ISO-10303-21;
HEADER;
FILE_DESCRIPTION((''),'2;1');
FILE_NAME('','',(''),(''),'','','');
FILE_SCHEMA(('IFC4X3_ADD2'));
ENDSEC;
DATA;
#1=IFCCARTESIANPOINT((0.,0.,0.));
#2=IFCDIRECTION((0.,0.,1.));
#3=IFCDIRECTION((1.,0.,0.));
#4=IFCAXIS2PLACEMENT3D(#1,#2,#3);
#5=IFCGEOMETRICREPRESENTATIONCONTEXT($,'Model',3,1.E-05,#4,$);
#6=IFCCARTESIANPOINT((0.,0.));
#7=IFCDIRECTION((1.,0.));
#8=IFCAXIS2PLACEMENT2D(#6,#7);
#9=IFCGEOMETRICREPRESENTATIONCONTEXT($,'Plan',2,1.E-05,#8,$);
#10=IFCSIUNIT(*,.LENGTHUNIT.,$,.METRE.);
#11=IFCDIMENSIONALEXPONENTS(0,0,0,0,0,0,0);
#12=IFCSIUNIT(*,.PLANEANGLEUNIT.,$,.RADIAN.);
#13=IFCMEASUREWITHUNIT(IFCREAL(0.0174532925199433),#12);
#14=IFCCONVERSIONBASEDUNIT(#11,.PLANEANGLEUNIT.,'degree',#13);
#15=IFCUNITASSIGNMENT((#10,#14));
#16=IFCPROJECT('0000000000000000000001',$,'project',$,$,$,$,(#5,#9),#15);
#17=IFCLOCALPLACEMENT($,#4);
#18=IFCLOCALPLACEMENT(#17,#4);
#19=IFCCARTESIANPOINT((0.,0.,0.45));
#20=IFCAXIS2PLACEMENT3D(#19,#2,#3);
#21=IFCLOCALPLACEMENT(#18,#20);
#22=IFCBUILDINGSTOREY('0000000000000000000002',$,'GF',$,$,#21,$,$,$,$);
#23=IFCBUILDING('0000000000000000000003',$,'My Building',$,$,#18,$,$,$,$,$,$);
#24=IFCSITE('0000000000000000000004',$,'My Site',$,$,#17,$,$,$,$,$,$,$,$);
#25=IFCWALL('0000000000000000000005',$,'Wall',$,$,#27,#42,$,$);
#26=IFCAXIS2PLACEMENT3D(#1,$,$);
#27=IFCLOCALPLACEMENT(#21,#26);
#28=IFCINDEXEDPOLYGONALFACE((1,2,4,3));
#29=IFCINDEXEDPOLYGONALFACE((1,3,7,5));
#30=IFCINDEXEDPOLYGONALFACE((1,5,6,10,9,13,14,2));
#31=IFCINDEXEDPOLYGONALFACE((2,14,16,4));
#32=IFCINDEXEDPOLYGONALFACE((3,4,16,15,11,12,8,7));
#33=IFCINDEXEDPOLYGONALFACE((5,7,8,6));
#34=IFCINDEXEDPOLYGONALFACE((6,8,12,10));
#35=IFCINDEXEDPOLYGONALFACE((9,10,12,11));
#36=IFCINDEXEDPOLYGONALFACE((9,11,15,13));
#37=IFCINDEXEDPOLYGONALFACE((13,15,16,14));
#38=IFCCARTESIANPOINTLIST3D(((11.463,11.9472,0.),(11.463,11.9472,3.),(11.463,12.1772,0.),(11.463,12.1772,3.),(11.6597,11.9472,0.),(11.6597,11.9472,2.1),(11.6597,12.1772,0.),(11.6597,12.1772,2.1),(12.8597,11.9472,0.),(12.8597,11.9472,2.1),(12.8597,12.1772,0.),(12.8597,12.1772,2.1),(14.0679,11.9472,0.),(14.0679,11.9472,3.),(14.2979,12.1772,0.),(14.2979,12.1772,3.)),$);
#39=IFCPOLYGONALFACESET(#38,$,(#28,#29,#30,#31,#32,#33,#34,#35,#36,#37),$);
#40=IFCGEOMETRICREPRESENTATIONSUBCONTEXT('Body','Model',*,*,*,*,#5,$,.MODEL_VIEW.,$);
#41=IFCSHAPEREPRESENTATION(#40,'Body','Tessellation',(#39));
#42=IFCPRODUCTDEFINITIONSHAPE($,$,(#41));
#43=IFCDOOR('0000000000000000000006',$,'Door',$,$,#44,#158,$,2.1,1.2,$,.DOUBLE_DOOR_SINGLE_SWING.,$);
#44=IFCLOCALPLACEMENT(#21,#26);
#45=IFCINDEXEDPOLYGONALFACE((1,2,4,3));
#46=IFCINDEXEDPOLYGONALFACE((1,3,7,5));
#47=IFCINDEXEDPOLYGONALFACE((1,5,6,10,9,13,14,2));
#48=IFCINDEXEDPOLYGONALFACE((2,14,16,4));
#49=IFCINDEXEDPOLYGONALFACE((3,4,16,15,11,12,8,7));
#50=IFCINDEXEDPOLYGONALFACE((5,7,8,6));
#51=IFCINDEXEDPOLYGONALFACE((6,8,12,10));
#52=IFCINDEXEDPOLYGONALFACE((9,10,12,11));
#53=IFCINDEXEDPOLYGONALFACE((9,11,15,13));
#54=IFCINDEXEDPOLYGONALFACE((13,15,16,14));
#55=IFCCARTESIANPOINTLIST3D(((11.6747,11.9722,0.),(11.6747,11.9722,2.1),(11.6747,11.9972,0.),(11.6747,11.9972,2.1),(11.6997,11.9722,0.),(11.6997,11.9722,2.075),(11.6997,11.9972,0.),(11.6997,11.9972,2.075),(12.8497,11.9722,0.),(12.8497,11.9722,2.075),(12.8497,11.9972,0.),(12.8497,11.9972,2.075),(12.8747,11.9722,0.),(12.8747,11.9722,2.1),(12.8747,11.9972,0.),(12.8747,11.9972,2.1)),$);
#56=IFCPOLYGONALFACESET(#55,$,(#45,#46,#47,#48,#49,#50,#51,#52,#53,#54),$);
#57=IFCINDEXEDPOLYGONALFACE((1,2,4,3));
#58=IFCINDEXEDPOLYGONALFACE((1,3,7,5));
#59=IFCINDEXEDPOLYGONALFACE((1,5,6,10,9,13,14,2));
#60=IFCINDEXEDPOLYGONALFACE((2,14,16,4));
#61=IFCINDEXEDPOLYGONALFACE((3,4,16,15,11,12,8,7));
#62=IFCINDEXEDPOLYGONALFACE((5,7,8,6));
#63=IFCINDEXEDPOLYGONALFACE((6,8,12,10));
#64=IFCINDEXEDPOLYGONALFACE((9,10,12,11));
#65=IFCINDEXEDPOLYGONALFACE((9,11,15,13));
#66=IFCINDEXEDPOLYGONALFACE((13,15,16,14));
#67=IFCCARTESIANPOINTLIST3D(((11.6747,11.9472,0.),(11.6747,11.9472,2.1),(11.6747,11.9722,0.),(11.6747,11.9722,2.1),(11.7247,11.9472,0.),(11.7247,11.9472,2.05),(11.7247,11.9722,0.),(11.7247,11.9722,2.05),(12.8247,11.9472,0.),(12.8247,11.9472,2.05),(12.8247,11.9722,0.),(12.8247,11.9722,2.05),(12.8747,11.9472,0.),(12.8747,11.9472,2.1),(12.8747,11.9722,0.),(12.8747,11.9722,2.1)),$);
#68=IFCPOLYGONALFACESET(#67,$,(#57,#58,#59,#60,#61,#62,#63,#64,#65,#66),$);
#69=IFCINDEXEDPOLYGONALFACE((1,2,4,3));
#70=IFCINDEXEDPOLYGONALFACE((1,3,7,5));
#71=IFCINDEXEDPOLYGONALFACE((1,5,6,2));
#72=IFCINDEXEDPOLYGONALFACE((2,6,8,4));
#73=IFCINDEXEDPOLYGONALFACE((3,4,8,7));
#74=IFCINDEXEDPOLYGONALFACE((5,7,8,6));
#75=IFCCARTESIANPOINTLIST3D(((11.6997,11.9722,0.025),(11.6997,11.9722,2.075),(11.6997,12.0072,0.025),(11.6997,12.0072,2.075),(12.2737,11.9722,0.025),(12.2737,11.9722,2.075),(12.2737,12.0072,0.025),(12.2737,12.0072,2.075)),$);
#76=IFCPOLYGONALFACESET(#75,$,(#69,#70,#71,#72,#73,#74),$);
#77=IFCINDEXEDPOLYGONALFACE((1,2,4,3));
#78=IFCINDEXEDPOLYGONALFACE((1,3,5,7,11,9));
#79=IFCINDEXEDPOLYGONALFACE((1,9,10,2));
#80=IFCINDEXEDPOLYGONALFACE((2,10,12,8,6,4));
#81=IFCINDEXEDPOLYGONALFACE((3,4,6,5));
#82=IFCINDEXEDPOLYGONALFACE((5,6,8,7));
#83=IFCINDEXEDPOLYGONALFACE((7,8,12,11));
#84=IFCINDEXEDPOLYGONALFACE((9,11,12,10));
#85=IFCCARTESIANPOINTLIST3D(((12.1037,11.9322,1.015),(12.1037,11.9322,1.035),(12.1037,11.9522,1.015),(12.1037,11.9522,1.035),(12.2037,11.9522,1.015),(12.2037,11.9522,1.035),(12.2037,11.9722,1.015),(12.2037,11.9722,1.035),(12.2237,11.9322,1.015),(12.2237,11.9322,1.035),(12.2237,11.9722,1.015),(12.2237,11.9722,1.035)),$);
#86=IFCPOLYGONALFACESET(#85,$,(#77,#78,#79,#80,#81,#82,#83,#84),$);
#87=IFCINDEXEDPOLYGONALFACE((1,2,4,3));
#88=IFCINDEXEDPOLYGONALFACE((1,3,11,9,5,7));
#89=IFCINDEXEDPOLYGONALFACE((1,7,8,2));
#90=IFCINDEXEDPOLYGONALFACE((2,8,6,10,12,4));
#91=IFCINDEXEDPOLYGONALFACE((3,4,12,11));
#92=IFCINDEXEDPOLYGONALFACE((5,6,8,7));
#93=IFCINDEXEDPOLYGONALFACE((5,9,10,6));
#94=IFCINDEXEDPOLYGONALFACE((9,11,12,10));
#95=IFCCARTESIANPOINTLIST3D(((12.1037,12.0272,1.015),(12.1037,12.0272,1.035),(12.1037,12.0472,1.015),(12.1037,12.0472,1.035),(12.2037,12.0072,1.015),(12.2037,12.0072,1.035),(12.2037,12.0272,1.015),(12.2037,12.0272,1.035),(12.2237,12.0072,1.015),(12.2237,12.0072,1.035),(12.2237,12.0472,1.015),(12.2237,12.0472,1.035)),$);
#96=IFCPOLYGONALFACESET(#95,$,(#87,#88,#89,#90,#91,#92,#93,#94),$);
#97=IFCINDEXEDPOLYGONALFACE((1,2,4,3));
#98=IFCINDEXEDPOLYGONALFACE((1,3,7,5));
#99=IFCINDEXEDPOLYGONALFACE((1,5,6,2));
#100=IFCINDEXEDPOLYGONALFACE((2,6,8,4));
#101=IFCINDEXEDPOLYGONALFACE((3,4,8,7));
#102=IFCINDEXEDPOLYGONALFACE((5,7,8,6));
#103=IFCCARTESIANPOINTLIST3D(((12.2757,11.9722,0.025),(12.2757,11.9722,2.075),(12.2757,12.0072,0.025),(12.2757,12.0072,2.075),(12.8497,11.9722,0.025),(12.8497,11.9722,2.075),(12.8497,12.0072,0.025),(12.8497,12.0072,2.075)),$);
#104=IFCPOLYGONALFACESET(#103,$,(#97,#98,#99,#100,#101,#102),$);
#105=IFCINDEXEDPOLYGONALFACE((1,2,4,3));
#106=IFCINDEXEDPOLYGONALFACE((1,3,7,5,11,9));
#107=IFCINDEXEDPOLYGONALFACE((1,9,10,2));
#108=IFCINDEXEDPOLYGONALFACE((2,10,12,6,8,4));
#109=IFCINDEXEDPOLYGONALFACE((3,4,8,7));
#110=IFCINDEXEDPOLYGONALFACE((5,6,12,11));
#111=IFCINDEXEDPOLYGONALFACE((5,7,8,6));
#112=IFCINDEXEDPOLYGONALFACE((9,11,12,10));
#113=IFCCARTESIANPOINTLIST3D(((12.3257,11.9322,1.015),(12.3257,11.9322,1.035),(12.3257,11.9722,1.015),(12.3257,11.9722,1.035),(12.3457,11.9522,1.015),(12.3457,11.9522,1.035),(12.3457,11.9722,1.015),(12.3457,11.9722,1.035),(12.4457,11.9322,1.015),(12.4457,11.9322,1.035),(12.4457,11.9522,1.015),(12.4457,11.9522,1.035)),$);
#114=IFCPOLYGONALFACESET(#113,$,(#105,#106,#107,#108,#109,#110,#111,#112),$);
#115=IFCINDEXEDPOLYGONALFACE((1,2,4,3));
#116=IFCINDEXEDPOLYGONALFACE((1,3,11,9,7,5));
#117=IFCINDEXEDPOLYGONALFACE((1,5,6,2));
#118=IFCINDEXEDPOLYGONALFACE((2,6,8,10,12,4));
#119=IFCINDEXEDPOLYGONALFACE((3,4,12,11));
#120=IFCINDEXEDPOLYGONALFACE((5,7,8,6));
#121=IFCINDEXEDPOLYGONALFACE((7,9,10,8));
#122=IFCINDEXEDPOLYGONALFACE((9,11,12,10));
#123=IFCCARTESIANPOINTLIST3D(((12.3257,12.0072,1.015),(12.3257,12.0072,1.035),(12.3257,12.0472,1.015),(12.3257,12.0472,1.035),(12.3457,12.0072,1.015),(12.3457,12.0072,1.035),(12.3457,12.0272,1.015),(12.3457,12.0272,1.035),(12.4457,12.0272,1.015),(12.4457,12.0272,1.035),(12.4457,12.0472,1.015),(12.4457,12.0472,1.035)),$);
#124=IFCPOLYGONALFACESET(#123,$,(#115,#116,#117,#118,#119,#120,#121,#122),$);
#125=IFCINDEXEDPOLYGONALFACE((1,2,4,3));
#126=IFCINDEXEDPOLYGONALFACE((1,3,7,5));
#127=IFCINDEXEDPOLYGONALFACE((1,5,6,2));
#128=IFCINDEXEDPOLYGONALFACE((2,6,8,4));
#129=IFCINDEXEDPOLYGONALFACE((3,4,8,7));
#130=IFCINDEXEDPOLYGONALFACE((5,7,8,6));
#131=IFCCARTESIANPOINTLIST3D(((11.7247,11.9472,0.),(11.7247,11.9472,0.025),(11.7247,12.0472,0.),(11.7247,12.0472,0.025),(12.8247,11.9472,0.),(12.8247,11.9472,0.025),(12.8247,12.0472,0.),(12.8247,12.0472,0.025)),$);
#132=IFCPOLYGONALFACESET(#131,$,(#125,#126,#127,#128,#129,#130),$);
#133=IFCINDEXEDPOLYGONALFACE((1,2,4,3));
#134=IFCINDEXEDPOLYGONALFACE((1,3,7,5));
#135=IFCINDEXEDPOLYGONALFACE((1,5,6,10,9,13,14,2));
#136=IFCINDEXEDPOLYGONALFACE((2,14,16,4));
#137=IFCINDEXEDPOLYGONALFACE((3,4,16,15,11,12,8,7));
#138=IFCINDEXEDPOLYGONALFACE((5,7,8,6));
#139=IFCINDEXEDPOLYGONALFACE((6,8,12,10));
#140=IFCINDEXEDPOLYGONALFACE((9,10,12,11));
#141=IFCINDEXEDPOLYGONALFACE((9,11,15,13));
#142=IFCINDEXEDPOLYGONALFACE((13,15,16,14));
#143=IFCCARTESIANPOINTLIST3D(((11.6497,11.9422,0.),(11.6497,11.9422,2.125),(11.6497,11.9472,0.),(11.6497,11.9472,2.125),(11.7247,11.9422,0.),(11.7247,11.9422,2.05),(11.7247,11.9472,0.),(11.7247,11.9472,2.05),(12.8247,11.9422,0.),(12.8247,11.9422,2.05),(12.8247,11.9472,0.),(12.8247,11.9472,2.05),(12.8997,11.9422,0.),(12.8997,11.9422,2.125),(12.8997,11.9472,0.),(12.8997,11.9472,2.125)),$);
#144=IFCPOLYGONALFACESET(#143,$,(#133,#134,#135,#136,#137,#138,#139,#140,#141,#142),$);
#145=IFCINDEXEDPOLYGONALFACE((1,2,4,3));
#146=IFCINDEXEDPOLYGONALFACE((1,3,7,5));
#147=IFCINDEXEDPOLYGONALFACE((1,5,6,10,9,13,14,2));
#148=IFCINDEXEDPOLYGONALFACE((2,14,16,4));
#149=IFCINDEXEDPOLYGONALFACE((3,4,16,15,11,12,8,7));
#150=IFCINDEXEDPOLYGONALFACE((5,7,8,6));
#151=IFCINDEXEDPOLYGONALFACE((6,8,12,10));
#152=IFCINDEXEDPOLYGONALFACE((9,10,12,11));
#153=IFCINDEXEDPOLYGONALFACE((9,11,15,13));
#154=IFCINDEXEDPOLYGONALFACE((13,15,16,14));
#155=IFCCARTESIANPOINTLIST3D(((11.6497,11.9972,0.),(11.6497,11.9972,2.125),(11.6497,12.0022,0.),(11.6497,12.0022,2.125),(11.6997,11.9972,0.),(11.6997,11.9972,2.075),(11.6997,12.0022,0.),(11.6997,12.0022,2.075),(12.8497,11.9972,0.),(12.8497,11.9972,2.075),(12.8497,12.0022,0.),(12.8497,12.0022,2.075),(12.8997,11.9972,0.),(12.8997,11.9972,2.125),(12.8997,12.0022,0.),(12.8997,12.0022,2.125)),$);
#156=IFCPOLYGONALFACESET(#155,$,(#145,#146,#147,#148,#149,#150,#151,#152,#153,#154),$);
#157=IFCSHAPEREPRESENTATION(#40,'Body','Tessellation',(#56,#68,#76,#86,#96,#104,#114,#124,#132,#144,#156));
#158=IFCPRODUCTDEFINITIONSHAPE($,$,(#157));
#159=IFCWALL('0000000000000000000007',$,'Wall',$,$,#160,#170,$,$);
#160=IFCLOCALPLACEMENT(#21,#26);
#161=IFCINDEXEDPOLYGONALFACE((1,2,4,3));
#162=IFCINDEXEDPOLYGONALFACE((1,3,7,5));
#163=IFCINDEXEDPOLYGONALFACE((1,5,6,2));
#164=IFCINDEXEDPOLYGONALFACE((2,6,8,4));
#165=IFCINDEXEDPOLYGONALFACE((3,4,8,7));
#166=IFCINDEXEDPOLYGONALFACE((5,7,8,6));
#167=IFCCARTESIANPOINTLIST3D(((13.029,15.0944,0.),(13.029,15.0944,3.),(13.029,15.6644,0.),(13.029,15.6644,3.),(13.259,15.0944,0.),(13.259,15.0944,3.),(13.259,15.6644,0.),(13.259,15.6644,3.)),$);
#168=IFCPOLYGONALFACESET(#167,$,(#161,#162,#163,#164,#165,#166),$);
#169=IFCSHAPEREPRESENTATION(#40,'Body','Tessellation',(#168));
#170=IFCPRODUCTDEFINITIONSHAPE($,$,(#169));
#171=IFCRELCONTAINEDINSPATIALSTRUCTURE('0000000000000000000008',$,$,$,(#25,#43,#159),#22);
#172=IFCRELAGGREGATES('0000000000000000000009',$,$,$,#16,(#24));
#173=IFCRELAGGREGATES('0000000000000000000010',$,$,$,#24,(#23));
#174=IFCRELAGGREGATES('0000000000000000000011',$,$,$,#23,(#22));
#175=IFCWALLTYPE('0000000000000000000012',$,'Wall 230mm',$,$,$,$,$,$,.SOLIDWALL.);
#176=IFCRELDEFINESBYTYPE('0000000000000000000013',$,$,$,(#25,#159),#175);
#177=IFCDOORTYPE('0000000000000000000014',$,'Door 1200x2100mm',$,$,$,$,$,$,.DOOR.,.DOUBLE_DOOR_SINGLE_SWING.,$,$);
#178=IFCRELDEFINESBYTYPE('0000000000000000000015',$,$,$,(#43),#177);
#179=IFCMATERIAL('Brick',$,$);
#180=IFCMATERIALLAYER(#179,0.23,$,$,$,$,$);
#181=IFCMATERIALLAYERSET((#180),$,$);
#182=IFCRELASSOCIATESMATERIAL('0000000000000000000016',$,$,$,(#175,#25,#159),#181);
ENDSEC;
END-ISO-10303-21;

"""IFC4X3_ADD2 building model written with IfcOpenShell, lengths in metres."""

from ifc_helpers import new_model, entity, si_unit, converted_unit, frame, origin_with_axes, origin_2d_with_axis, place, context, subcontext, project, spatial, line, indexed_curve, outline, extrude, clip, halfspace, shape, source, transform, mapped, material, layer, layer_set, layer_usage, type_object, type_shapes, element, fill, save


model = new_model("IFC4X3_ADD2")

# Units and contexts
model_context = context("Model", 3, precision=1e-05, world=origin_with_axes())
plan_context = context("Plan", 2, precision=1e-05, world=origin_2d_with_axis())
body_context_1 = subcontext(model_context, "Body", "Model", "MODEL_VIEW")
body_context_2 = subcontext(plan_context, "Body", "Plan", "PLAN_VIEW")
ifc_project = project(units=[si_unit("LENGTHUNIT", "METRE"), converted_unit("PLANEANGLEUNIT", "degree", entity("IfcReal", 0.0174532925199433), si_unit("PLANEANGLEUNIT", "RADIAN"), dimensions=[0, 0, 0, 0, 0, 0, 0])], contexts=[model_context, plan_context])

# Site, building, storey
site_placement = place(None, origin_with_axes())
site = spatial("IfcSite", under=ifc_project, at=site_placement, Name="My Site")
building_placement = place(site_placement, origin_with_axes())
building = spatial("IfcBuilding", under=site, at=building_placement, Name="My Building")
storey_placement = place(building_placement, frame((0.0, 0.0, 0.45), z_axis=(0.0, 0.0, 1.0), x_axis=(1.0, 0.0, 0.0)))
storey = spatial("IfcBuildingStorey", under=building, at=storey_placement, Name="GF")

# Shared definitions
ifc_material_1 = material(Name="Brick")
ifc_layer_1 = layer(ifc_material_1, 0.23)
ifc_layer_set_1 = layer_set([ifc_layer_1])
wall_type = type_object("IfcWallType", Name="Wall 230mm", PredefinedType="SOLIDWALL", material=ifc_layer_set_1)

# Wall, opening, door
ifc_layer_usage_1 = layer_usage(ifc_layer_set_1, "AXIS2", "POSITIVE", 0.0)
wall_1_placement = place(storey_placement, frame((11.463, 11.9472, 0.0), z_axis=(0.0, 0.0, 1.0), x_axis=(1.0, 0.0, 0.0)))
wall_1 = element("IfcWall", 1, at=wall_1_placement, inside=storey, type_object=wall_type, material=ifc_layer_usage_1, Name="Wall", context=body_context_1, shape_type="Clipping", body=[
    clip(extrude(outline(indexed_curve([(0.0, 0.0), (0.0, 0.23), (3.1602, 0.23), (3.1602, 0.0), (0.0, 0.0)], self_intersect=False)), origin_with_axes(), (0.0, 0.0, 1.0), 3.0), halfspace(frame((2.6049, 0.0, -0.45), z_axis=(0.690001, -0.689999, 0.0), x_axis=(-0.707105, -0.707108, 0.0)), False)),
])
shared_shape_1 = source(origin_with_axes(), body_context_1, "Body", "SweptSolid", [
    extrude(outline(indexed_curve([(0.0, 0.0), (1.2, 0.0), (1.2, 2.1), (0.0, 2.1)], segments=[line(1, 2, 3, 4, 1)])), frame((0.0, -0.6, 0.0), z_axis=(0.0, -1.0, 0.0), x_axis=(1.0, 0.0, 0.0)), (0.0, 0.0, -1.0), 1.2),
])
opening_1_placement = place(wall_1_placement, frame((0.1967, 0.0088, 0.0), z_axis=(0.0, 0.0, 1.0), x_axis=(1.0, 0.0, 0.0)))
opening_1 = element("IfcOpeningElement", 2, at=opening_1_placement, cuts=wall_1, PredefinedType="OPENING", context=body_context_1, shape_type="MappedRepresentation", body=[
    mapped(shared_shape_1, transform((0.0, 0.0, 0.0), x_axis=(1.0, 0.0, 0.0), y_axis=(0.0, 1.0, 0.0), z_axis=(0.0, 0.0, 1.0), scale=1.0)),
])
door_type_1 = type_object("IfcDoorType", Name="Door 1200x2100mm", OperationType="DOUBLE_DOOR_SINGLE_SWING", PredefinedType="DOOR")
shared_shape_2 = source(origin_with_axes(), body_context_1, "Body", "SweptSolid", [
    extrude(outline(indexed_curve([(0.0, 0.0), (0.0, 2.1), (1.2, 2.1), (1.2, 0.0), (1.175, 0.0), (1.175, 2.075), (0.025, 2.075), (0.025, 0.0)], segments=[line(1, 2, 3, 4, 5, 6, 7, 8, 1)])), frame((0.0, 0.025, 0.0), z_axis=(0.0, -1.0, 0.0), x_axis=(1.0, 0.0, 0.0)), (0.0, 0.0, -1.0), 0.025),
    extrude(outline(indexed_curve([(0.0, 0.0), (0.0, 2.1), (1.2, 2.1), (1.2, 0.0), (1.15, 0.0), (1.15, 2.05), (0.05, 2.05), (0.05, 0.0)], segments=[line(1, 2, 3, 4, 5, 6, 7, 8, 1)])), frame((0.0, 0.0, 0.0), z_axis=(0.0, -1.0, 0.0), x_axis=(1.0, 0.0, 0.0)), (0.0, 0.0, -1.0), 0.025),
    extrude(outline(indexed_curve([(0.0, 0.0), (0.574, 0.0), (0.574, 0.035), (0.0, 0.035)], segments=[line(1, 2, 3, 4, 1)])), frame((0.025, 0.025, 0.025), z_axis=(0.0, 0.0, 1.0), x_axis=(1.0, 0.0, 0.0)), (0.0, 0.0, 1.0), 2.05),
    extrude(outline(indexed_curve([(0.0, 0.0), (0.0, -0.04), (-0.12, -0.04), (-0.12, -0.02), (-0.02, -0.02), (-0.02, 0.0)], segments=[line(1, 2, 3, 4, 5, 6, 1)])), frame((0.549, 0.025, 1.015), z_axis=(0.0, 0.0, 1.0), x_axis=(1.0, 0.0, 0.0)), (0.0, 0.0, 1.0), 0.02),
    extrude(outline(indexed_curve([(0.0, 0.0), (0.0, 0.04), (-0.12, 0.04), (-0.12, 0.02), (-0.02, 0.02), (-0.02, 0.0)], segments=[line(1, 2, 3, 4, 5, 6, 1)])), frame((0.549, 0.06, 1.015), z_axis=(0.0, 0.0, 1.0), x_axis=(1.0, 0.0, 0.0)), (0.0, 0.0, 1.0), 0.02),
    extrude(outline(indexed_curve([(0.0, 0.0), (-0.574, 0.0), (-0.574, 0.035), (0.0, 0.035)], segments=[line(1, 2, 3, 4, 1)])), frame((1.175, 0.025, 0.025), z_axis=(0.0, 0.0, 1.0), x_axis=(1.0, 0.0, 0.0)), (0.0, 0.0, 1.0), 2.05),
    extrude(outline(indexed_curve([(0.0, 0.0), (0.0, -0.04), (0.12, -0.04), (0.12, -0.02), (0.02, -0.02), (0.02, 0.0)], segments=[line(1, 2, 3, 4, 5, 6, 1)])), frame((0.651, 0.025, 1.015), z_axis=(0.0, 0.0, 1.0), x_axis=(1.0, 0.0, 0.0)), (0.0, 0.0, 1.0), 0.02),
    extrude(outline(indexed_curve([(0.0, 0.0), (0.0, 0.04), (0.12, 0.04), (0.12, 0.02), (0.02, 0.02), (0.02, 0.0)], segments=[line(1, 2, 3, 4, 5, 6, 1)])), frame((0.651, 0.06, 1.015), z_axis=(0.0, 0.0, 1.0), x_axis=(1.0, 0.0, 0.0)), (0.0, 0.0, 1.0), 0.02),
    extrude(outline(indexed_curve([(0.0, 0.0), (1.1, 0.0), (1.1, 0.1), (0.0, 0.1)], segments=[line(1, 2, 3, 4, 1)])), frame((0.05, 0.0, 0.0), z_axis=(0.0, 0.0, 1.0), x_axis=(1.0, 0.0, 0.0)), (0.0, 0.0, 1.0), 0.025),
    extrude(outline(indexed_curve([(0.0, 0.0), (0.0, 2.125), (1.25, 2.125), (1.25, 0.0), (1.175, 0.0), (1.175, 2.05), (0.075, 2.05), (0.075, 0.0)], segments=[line(1, 2, 3, 4, 5, 6, 7, 8, 1)])), frame((-0.025, -0.005, 0.0), z_axis=(0.0, -1.0, 0.0), x_axis=(1.0, 0.0, 0.0)), (0.0, 0.0, -1.0), 0.005),
    extrude(outline(indexed_curve([(0.0, 0.0), (0.0, 2.125), (1.25, 2.125), (1.25, 0.0), (1.2, 0.0), (1.2, 2.075), (0.05, 2.075), (0.05, 0.0)], segments=[line(1, 2, 3, 4, 5, 6, 7, 8, 1)])), frame((-0.025, 0.05, 0.0), z_axis=(0.0, -1.0, 0.0), x_axis=(1.0, 0.0, 0.0)), (0.0, 0.0, -1.0), 0.005),
])
shared_shape_3 = source(origin_with_axes(), body_context_2, "Body", "Curve2D", [
    entity("IfcIndexedPolyCurve", entity("IfcCartesianPointList2D", [[0.0, 0.0], [0.0, 0.05], [0.025, 0.05], [0.025, 0.025], [0.05, 0.025], [0.05, 0.0]]), [entity("IfcLineIndex", [1, 2, 3, 4, 5, 6, 1])]),
    entity("IfcIndexedPolyCurve", entity("IfcCartesianPointList2D", [[1.2, 0.0], [1.2, 0.05], [1.175, 0.05], [1.175, 0.025], [1.15, 0.025], [1.15, 0.0]]), [entity("IfcLineIndex", [1, 2, 3, 4, 5, 6, 1])]),
    entity("IfcTrimmedCurve", entity("IfcEllipse", entity("IfcAxis2Placement2D", entity("IfcCartesianPoint", [0.06, 0.05]), entity("IfcDirection", [1.0, 0.0])), 0.54, 0.575), [entity("IfcCartesianPoint", [0.6, 0.05])], [entity("IfcCartesianPoint", [0.06, 0.625])], True, "CARTESIAN"),
    entity("IfcIndexedPolyCurve", entity("IfcCartesianPointList2D", [[0.025, 0.05], [0.06, 0.05], [0.06, 0.625], [0.025, 0.625]]), [entity("IfcLineIndex", [1, 2, 3, 4, 1])]),
    entity("IfcTrimmedCurve", entity("IfcEllipse", entity("IfcAxis2Placement2D", entity("IfcCartesianPoint", [1.14, 0.05]), entity("IfcDirection", [1.0, 0.0])), 0.54, 0.575), [entity("IfcCartesianPoint", [1.14, 0.625])], [entity("IfcCartesianPoint", [0.6, 0.05])], True, "CARTESIAN"),
    entity("IfcIndexedPolyCurve", entity("IfcCartesianPointList2D", [[1.175, 0.05], [1.14, 0.05], [1.14, 0.625], [1.175, 0.625]]), [entity("IfcLineIndex", [1, 2, 3, 4, 1])]),
])
type_shapes(door_type_1, [shared_shape_2, shared_shape_3])
door_1_placement = place(opening_1_placement, frame((0.015, -0.0088, 0.0), z_axis=(0.0, 0.0, 1.0), x_axis=(1.0, 0.0, 0.0)))
door_1 = element("IfcDoor", 3, at=door_1_placement, inside=storey, type_object=door_type_1, Name="Door", OperationType="DOUBLE_DOOR_SINGLE_SWING", OverallHeight=2.1, OverallWidth=1.2, shapes=[
    shape(body_context_1, "Body", "MappedRepresentation", [mapped(shared_shape_2, transform((0.0, 0.0, 0.0), x_axis=(1.0, 0.0, 0.0), y_axis=(0.0, 1.0, 0.0), z_axis=(0.0, 0.0, 1.0), scale=1.0))]),
    shape(body_context_2, "Body", "MappedRepresentation", [mapped(shared_shape_3, transform((0.0, 0.0, 0.0), x_axis=(1.0, 0.0, 0.0), y_axis=(0.0, 1.0, 0.0), z_axis=(0.0, 0.0, 1.0), scale=1.0))]),
])
fill(opening_1, door_1)

# Wall
ifc_layer_usage_2 = layer_usage(ifc_layer_set_1, "AXIS2", "POSITIVE", 0.0)
wall_2_placement = place(storey_placement, frame((13.259, 15.0944, 0.0), z_axis=(0.0, 0.0, 1.0), x_axis=(0.0, 1.0, 0.0)))
element("IfcWall", 4, at=wall_2_placement, inside=storey, type_object=wall_type, material=ifc_layer_usage_2, Name="Wall", context=body_context_1, shape_type="SweptSolid", body=[
    extrude(outline(indexed_curve([(0.0, 0.0), (0.0, 0.23), (0.57, 0.23), (0.57, 0.0), (0.0, 0.0)], self_intersect=False)), origin_with_axes(), (0.0, 0.0, 1.0), 3.0),
])

save(model, "model.ifc")
